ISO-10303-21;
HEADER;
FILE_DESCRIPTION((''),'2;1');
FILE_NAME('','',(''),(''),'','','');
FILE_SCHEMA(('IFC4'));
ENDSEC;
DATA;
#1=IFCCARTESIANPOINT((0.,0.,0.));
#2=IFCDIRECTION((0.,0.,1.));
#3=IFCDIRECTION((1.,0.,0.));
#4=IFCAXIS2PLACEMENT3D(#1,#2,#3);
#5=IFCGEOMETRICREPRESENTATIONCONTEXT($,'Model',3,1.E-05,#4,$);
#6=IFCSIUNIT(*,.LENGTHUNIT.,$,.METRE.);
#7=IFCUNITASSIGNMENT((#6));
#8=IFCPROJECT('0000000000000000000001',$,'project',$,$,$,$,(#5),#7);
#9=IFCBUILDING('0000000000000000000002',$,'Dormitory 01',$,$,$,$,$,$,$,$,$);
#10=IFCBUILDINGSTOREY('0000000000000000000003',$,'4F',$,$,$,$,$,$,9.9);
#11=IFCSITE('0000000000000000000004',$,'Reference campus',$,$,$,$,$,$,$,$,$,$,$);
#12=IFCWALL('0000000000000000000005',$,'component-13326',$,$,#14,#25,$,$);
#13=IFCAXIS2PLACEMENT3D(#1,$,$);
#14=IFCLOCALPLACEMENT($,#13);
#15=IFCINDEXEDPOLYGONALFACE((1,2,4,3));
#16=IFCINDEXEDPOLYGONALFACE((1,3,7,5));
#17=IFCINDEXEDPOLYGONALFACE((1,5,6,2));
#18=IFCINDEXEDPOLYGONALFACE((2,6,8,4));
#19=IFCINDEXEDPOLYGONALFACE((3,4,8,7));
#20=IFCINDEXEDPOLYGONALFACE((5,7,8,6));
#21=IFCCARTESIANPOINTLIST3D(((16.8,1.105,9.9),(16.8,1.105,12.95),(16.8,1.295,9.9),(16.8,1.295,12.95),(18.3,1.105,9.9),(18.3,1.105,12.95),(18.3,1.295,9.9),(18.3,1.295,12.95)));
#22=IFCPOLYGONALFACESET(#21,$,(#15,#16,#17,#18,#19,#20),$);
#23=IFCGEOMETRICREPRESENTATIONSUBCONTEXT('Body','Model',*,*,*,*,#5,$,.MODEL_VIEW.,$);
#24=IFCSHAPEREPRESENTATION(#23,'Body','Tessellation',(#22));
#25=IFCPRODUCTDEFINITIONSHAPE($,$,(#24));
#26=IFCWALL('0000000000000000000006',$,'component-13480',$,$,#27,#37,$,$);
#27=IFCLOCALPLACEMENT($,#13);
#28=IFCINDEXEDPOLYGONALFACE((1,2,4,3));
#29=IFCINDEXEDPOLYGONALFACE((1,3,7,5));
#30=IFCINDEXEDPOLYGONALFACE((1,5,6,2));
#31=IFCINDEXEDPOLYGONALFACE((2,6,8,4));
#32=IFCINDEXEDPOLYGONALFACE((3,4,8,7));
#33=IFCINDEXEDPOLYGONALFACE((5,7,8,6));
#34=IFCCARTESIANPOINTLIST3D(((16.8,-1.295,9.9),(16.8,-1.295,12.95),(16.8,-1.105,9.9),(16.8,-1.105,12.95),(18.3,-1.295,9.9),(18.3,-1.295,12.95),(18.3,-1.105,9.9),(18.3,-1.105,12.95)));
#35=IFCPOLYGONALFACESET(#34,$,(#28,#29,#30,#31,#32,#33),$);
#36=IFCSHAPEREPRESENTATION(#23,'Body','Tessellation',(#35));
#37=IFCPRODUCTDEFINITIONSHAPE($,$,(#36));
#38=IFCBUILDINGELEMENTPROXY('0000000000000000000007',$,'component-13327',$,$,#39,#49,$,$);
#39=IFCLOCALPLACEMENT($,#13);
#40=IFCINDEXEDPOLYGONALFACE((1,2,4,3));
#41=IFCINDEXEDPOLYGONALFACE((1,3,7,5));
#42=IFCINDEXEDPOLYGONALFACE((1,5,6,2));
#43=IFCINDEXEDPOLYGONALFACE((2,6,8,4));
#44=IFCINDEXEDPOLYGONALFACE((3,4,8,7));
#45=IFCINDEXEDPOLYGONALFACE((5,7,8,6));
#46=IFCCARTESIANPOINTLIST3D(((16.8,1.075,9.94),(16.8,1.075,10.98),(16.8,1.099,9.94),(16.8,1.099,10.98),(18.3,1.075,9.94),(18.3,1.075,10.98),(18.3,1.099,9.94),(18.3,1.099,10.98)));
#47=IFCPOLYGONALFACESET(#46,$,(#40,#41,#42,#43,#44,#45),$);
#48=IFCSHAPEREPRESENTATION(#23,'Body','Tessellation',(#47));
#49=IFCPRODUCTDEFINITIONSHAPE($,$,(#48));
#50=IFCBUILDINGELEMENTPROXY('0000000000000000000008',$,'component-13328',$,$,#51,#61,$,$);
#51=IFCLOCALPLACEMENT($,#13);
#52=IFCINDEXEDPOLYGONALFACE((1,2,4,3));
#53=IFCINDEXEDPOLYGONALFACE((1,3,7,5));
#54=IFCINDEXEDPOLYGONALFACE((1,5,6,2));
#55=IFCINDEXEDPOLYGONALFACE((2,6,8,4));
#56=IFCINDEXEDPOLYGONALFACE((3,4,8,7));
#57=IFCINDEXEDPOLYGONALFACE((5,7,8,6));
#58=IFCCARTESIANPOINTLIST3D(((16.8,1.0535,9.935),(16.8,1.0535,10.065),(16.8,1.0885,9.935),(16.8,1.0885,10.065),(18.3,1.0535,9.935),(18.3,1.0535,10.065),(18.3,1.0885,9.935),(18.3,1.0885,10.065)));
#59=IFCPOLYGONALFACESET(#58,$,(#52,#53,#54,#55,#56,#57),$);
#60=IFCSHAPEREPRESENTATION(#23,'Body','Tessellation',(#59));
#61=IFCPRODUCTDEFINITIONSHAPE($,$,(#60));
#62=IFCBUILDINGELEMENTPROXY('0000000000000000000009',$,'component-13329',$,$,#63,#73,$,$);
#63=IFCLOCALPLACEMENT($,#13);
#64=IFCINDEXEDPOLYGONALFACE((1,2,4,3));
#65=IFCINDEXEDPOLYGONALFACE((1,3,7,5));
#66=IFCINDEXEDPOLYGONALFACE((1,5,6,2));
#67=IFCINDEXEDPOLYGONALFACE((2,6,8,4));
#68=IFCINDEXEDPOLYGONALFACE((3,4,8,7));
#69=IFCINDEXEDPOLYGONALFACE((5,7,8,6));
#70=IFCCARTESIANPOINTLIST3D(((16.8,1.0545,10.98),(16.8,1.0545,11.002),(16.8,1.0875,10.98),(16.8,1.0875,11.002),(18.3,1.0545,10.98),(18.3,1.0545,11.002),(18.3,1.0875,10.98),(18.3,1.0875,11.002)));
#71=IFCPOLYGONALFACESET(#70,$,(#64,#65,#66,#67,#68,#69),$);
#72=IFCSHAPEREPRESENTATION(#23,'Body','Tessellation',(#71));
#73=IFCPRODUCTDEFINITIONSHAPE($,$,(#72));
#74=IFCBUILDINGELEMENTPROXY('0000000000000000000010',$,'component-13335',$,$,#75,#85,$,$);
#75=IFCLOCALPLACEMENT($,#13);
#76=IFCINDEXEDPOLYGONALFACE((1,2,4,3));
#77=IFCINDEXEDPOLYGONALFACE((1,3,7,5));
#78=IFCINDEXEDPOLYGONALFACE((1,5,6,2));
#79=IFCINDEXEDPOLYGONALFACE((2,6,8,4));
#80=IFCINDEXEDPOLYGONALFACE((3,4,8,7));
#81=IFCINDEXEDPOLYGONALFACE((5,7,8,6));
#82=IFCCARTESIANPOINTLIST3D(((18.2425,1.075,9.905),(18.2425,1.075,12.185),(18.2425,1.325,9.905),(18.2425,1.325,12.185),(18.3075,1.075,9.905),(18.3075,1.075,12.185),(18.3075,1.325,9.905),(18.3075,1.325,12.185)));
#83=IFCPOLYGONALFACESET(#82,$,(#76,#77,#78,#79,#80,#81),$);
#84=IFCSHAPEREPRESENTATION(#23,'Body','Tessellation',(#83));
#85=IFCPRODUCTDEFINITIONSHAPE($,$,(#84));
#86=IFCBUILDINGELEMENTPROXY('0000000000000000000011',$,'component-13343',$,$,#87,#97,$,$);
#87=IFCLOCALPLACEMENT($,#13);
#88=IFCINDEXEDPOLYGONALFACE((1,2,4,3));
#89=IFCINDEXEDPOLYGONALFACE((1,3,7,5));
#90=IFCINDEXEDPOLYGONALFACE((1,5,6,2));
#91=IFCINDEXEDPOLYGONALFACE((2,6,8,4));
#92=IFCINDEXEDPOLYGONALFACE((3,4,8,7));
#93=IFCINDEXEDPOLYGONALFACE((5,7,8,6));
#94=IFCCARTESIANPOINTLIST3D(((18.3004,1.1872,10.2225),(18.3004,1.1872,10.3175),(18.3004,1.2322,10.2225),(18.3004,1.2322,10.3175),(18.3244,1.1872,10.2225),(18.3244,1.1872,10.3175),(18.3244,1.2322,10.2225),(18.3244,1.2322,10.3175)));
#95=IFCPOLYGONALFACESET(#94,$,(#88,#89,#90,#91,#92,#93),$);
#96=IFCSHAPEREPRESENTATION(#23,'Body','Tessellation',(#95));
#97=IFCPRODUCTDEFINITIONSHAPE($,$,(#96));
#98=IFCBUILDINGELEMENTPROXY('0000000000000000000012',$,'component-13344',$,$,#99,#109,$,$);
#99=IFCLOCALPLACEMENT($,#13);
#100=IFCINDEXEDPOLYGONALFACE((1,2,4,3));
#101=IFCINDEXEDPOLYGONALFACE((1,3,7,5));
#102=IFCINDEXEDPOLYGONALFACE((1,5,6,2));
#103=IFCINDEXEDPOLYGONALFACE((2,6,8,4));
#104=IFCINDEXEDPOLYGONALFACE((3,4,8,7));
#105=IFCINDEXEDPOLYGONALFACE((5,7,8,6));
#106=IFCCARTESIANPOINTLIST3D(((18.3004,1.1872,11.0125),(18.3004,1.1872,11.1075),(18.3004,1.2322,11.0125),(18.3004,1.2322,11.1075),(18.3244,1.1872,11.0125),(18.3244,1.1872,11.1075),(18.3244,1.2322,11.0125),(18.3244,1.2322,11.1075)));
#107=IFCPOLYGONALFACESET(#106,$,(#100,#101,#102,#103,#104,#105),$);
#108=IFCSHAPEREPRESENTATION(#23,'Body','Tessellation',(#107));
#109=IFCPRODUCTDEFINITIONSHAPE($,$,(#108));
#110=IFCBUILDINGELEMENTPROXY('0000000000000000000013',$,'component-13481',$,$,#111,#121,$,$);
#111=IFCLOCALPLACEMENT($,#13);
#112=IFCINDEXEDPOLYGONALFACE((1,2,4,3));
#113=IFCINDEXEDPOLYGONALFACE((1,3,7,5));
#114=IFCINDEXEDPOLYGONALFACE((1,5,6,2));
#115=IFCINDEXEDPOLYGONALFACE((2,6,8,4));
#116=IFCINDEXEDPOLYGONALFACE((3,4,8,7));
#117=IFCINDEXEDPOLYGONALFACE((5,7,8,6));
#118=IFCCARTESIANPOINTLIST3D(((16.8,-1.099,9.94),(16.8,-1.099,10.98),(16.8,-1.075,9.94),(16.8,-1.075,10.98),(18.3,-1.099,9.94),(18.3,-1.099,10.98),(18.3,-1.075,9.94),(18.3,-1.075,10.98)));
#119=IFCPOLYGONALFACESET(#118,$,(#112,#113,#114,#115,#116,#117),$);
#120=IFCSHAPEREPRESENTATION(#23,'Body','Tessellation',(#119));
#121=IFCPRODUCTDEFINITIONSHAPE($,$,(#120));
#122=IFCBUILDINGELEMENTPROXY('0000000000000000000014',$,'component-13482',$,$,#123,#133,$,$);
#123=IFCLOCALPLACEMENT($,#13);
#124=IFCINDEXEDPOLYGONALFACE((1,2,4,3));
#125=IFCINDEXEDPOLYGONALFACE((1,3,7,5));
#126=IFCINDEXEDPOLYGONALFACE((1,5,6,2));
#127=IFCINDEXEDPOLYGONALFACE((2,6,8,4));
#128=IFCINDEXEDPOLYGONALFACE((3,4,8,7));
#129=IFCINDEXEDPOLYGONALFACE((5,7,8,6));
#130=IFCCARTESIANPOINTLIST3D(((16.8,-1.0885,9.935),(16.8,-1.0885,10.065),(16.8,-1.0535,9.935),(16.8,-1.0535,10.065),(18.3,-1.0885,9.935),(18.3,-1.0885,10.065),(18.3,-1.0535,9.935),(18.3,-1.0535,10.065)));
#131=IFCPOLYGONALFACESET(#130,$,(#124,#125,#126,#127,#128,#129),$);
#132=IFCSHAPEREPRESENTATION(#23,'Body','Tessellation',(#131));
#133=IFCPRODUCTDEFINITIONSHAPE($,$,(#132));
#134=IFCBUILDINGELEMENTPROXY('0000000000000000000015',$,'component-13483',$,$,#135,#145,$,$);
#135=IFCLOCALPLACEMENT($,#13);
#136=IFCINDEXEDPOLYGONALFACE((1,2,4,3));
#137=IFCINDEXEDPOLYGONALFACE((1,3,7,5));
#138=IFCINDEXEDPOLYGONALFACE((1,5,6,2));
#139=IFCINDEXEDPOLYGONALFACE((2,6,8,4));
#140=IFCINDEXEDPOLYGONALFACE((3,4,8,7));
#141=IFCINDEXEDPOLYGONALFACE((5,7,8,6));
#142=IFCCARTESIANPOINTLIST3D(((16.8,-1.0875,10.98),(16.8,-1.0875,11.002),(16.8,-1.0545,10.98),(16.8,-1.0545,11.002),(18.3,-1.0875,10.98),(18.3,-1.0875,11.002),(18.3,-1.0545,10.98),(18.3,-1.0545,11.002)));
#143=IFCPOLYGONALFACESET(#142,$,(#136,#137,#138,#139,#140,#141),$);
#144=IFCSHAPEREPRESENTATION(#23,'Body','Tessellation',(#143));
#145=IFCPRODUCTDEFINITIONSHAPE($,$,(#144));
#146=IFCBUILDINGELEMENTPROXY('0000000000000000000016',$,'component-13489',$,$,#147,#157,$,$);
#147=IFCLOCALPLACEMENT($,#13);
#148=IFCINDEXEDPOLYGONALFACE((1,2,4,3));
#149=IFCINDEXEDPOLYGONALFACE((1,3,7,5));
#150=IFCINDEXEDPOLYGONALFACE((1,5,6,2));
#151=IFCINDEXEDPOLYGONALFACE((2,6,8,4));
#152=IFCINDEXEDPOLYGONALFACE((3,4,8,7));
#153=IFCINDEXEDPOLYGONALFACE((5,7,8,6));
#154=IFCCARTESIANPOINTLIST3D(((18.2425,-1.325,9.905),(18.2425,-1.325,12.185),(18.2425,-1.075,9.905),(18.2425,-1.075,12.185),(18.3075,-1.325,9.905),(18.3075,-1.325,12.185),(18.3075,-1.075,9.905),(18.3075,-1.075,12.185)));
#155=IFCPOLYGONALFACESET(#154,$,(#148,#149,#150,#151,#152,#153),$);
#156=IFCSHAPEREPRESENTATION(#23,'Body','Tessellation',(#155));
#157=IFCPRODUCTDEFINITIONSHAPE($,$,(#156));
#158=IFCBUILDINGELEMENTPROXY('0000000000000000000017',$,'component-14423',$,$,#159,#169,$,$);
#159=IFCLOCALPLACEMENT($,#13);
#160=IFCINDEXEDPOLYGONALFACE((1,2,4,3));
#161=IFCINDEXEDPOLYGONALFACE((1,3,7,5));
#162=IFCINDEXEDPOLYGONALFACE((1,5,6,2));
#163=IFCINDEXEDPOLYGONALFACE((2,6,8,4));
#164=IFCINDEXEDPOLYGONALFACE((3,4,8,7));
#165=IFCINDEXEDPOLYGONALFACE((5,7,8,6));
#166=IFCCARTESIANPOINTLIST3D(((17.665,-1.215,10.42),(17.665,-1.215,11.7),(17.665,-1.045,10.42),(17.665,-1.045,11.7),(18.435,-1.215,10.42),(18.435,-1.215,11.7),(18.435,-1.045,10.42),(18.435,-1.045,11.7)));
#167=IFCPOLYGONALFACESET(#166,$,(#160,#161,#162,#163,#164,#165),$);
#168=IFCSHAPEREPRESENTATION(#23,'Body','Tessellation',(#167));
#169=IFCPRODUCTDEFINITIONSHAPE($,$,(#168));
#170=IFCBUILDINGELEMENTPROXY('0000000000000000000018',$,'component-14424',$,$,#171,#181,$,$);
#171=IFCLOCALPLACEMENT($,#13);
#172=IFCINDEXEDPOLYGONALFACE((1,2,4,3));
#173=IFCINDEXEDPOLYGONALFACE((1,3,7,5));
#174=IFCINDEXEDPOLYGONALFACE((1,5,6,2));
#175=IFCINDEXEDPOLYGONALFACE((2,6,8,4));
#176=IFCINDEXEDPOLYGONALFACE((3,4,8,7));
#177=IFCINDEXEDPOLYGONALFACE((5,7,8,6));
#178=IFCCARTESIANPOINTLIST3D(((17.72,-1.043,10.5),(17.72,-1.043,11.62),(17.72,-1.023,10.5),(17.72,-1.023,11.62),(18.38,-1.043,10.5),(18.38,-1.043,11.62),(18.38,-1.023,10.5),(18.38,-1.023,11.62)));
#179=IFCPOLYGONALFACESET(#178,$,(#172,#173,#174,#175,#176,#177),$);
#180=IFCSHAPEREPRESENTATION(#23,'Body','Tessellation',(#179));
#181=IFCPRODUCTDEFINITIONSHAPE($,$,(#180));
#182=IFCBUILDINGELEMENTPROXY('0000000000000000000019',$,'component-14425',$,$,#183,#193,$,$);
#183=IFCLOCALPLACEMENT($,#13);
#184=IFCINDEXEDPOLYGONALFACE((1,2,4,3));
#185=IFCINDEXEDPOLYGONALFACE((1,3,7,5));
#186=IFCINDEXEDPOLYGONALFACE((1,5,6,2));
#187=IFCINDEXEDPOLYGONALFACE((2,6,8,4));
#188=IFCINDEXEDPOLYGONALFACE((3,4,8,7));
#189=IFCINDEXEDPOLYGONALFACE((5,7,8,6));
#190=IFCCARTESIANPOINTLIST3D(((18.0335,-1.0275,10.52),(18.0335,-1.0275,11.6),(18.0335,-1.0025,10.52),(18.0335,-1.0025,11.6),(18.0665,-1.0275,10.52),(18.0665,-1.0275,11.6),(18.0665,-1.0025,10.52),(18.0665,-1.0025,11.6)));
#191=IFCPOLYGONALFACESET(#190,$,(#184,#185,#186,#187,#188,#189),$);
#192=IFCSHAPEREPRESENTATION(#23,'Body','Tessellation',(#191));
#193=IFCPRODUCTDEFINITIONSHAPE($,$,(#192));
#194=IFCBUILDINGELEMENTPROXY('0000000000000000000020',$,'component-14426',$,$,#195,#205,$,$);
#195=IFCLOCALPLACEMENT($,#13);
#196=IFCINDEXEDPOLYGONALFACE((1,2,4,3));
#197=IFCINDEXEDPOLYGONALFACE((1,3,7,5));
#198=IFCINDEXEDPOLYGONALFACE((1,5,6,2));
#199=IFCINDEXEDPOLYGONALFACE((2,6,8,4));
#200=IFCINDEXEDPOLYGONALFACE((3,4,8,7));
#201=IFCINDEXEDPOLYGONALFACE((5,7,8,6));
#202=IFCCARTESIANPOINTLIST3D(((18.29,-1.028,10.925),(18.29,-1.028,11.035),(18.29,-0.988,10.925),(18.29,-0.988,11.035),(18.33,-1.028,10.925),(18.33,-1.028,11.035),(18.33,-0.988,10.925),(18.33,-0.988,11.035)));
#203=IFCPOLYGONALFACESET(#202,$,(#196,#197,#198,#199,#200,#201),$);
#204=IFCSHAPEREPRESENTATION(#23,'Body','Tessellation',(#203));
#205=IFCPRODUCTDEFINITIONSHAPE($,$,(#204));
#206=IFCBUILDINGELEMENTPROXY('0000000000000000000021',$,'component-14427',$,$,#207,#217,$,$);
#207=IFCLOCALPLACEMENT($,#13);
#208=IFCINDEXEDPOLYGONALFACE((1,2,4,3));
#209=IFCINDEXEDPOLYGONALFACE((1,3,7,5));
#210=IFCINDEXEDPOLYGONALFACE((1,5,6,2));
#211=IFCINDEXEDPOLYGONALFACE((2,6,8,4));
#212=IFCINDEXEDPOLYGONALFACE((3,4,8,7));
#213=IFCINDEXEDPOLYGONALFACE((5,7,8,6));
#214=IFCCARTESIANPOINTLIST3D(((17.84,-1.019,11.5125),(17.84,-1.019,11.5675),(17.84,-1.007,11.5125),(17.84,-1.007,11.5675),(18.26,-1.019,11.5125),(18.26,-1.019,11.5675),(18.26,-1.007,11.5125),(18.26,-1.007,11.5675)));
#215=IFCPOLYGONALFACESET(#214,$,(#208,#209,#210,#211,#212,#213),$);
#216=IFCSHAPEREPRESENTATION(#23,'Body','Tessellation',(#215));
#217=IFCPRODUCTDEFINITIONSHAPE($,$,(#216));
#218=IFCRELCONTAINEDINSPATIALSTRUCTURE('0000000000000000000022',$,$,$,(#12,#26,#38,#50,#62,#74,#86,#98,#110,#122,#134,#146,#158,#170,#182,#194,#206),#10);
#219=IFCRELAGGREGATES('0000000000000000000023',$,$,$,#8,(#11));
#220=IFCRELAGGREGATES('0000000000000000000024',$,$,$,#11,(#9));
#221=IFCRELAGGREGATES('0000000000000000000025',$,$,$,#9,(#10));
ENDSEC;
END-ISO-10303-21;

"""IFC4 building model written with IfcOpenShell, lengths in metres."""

from ifc_helpers import new_model, si_unit, frame, origin, origin_with_axes, origin_2d, place, context, subcontext, project, spatial, rectangle, extrude, element, save


model = new_model("IFC4")

# Units and contexts
model_context = context("Model", 3, precision=1e-05, world=origin_with_axes())
body_context = subcontext(model_context, "Body", "Model", "MODEL_VIEW")
ifc_project = project(units=[si_unit("LENGTHUNIT", "METRE")], contexts=[model_context])

# Site, building, storey
site = spatial("IfcSite", under=ifc_project, Name="Reference campus")
building = spatial("IfcBuilding", under=site, Name="Dormitory 01")
storey = spatial("IfcBuildingStorey", under=building, Name="4F", Elevation=9.9)

# Walls
for number, where, z_axis, x_axis, name in (
    (1, (17.55, 1.2, 9.9), (0.0, 0.0, 1.0), (1.0, 0.0, 0.0), "component-13326"),
    (2, (17.55, -1.2, 9.9), (0.0, 0.0, 1.0), (1.0, 0.0, 0.0), "component-13480"),
):
    element("IfcWall", number, at=place(None, frame(where, z_axis=z_axis, x_axis=x_axis)), inside=storey, Name=name, context=body_context, shape_type="SweptSolid", body=[
        extrude(rectangle(XDim=1.5, YDim=0.19, at=origin_2d()), origin(), (0.0, 0.0, 1.0), 3.05),
    ])

# Building element proxies
proxy_1_placement = place(None, frame((17.55, 1.087, 9.94), z_axis=(0.0, 0.0, 1.0), x_axis=(1.0, 0.0, 0.0)))
element("IfcBuildingElementProxy", 3, at=proxy_1_placement, inside=storey, Name="component-13327", context=body_context, shape_type="SweptSolid", body=[
    extrude(rectangle(XDim=1.5, YDim=0.024, at=origin_2d()), origin(), (0.0, 0.0, 1.0), 1.04),
])
proxy_2_placement = place(None, frame((17.55, 1.071, 9.935), z_axis=(0.0, 0.0, 1.0), x_axis=(1.0, 0.0, 0.0)))
element("IfcBuildingElementProxy", 4, at=proxy_2_placement, inside=storey, Name="component-13328", context=body_context, shape_type="SweptSolid", body=[
    extrude(rectangle(XDim=1.5, YDim=0.035, at=origin_2d()), origin(), (0.0, 0.0, 1.0), 0.13),
])
proxy_3_placement = place(None, frame((17.55, 1.071, 10.98), z_axis=(0.0, 0.0, 1.0), x_axis=(1.0, 0.0, 0.0)))
element("IfcBuildingElementProxy", 5, at=proxy_3_placement, inside=storey, Name="component-13329", context=body_context, shape_type="SweptSolid", body=[
    extrude(rectangle(XDim=1.5, YDim=0.033, at=origin_2d()), origin(), (0.0, 0.0, 1.0), 0.022),
])
proxy_4_placement = place(None, frame((18.275, 1.2, 9.905), z_axis=(0.0, 0.0, 1.0), x_axis=(1.0, 0.0, 0.0)))
element("IfcBuildingElementProxy", 6, at=proxy_4_placement, inside=storey, Name="component-13335", context=body_context, shape_type="SweptSolid", body=[
    extrude(rectangle(XDim=0.065, YDim=0.25, at=origin_2d()), origin(), (0.0, 0.0, 1.0), 2.28),
])
for number, where, z_axis, x_axis, name in (
    (7, (18.3124, 1.2097, 10.2225), (0.0, 0.0, 1.0), (1.0, 0.0, 0.0), "component-13343"),
    (8, (18.3124, 1.2097, 11.0125), (0.0, 0.0, 1.0), (1.0, 0.0, 0.0), "component-13344"),
):
    element("IfcBuildingElementProxy", number, at=place(None, frame(where, z_axis=z_axis, x_axis=x_axis)), inside=storey, Name=name, context=body_context, shape_type="SweptSolid", body=[
        extrude(rectangle(XDim=0.024, YDim=0.045, at=origin_2d()), origin(), (0.0, 0.0, 1.0), 0.095),
    ])
proxy_5_placement = place(None, frame((17.55, -1.087, 9.94), z_axis=(0.0, 0.0, 1.0), x_axis=(1.0, 0.0, 0.0)))
element("IfcBuildingElementProxy", 9, at=proxy_5_placement, inside=storey, Name="component-13481", context=body_context, shape_type="SweptSolid", body=[
    extrude(rectangle(XDim=1.5, YDim=0.024, at=origin_2d()), origin(), (0.0, 0.0, 1.0), 1.04),
])
proxy_6_placement = place(None, frame((17.55, -1.071, 9.935), z_axis=(0.0, 0.0, 1.0), x_axis=(1.0, 0.0, 0.0)))
element("IfcBuildingElementProxy", 10, at=proxy_6_placement, inside=storey, Name="component-13482", context=body_context, shape_type="SweptSolid", body=[
    extrude(rectangle(XDim=1.5, YDim=0.035, at=origin_2d()), origin(), (0.0, 0.0, 1.0), 0.13),
])
proxy_7_placement = place(None, frame((17.55, -1.071, 10.98), z_axis=(0.0, 0.0, 1.0), x_axis=(1.0, 0.0, 0.0)))
element("IfcBuildingElementProxy", 11, at=proxy_7_placement, inside=storey, Name="component-13483", context=body_context, shape_type="SweptSolid", body=[
    extrude(rectangle(XDim=1.5, YDim=0.033, at=origin_2d()), origin(), (0.0, 0.0, 1.0), 0.022),
])
proxy_8_placement = place(None, frame((18.275, -1.2, 9.905), z_axis=(0.0, 0.0, 1.0), x_axis=(1.0, 0.0, 0.0)))
element("IfcBuildingElementProxy", 12, at=proxy_8_placement, inside=storey, Name="component-13489", context=body_context, shape_type="SweptSolid", body=[
    extrude(rectangle(XDim=0.065, YDim=0.25, at=origin_2d()), origin(), (0.0, 0.0, 1.0), 2.28),
])
proxy_9_placement = place(None, frame((18.05, -1.13, 10.42), z_axis=(0.0, 0.0, 1.0), x_axis=(1.0, 0.0, 0.0)))
element("IfcBuildingElementProxy", 13, at=proxy_9_placement, inside=storey, Name="component-14423", context=body_context, shape_type="SweptSolid", body=[
    extrude(rectangle(XDim=0.77, YDim=0.17, at=origin_2d()), origin(), (0.0, 0.0, 1.0), 1.28),
])
proxy_10_placement = place(None, frame((18.05, -1.033, 10.5), z_axis=(0.0, 0.0, 1.0), x_axis=(1.0, 0.0, 0.0)))
element("IfcBuildingElementProxy", 14, at=proxy_10_placement, inside=storey, Name="component-14424", context=body_context, shape_type="SweptSolid", body=[
    extrude(rectangle(XDim=0.66, YDim=0.02, at=origin_2d()), origin(), (0.0, 0.0, 1.0), 1.12),
])
proxy_11_placement = place(None, frame((18.05, -1.015, 10.52), z_axis=(0.0, 0.0, 1.0), x_axis=(1.0, 0.0, 0.0)))
element("IfcBuildingElementProxy", 15, at=proxy_11_placement, inside=storey, Name="component-14425", context=body_context, shape_type="SweptSolid", body=[
    extrude(rectangle(XDim=0.033, YDim=0.025, at=origin_2d()), origin(), (0.0, 0.0, 1.0), 1.08),
])
proxy_12_placement = place(None, frame((18.31, -1.008, 10.925), z_axis=(0.0, 0.0, 1.0), x_axis=(1.0, 0.0, 0.0)))
element("IfcBuildingElementProxy", 16, at=proxy_12_placement, inside=storey, Name="component-14426", context=body_context, shape_type="SweptSolid", body=[
    extrude(rectangle(XDim=0.04, YDim=0.04, at=origin_2d()), origin(), (0.0, 0.0, 1.0), 0.11),
])
proxy_13_placement = place(None, frame((18.05, -1.013, 11.5125), z_axis=(0.0, 0.0, 1.0), x_axis=(1.0, 0.0, 0.0)))
element("IfcBuildingElementProxy", 17, at=proxy_13_placement, inside=storey, Name="component-14427", context=body_context, shape_type="SweptSolid", body=[
    extrude(rectangle(XDim=0.42, YDim=0.012, at=origin_2d()), origin(), (0.0, 0.0, 1.0), 0.055),
])

save(model, "model.ifc")
